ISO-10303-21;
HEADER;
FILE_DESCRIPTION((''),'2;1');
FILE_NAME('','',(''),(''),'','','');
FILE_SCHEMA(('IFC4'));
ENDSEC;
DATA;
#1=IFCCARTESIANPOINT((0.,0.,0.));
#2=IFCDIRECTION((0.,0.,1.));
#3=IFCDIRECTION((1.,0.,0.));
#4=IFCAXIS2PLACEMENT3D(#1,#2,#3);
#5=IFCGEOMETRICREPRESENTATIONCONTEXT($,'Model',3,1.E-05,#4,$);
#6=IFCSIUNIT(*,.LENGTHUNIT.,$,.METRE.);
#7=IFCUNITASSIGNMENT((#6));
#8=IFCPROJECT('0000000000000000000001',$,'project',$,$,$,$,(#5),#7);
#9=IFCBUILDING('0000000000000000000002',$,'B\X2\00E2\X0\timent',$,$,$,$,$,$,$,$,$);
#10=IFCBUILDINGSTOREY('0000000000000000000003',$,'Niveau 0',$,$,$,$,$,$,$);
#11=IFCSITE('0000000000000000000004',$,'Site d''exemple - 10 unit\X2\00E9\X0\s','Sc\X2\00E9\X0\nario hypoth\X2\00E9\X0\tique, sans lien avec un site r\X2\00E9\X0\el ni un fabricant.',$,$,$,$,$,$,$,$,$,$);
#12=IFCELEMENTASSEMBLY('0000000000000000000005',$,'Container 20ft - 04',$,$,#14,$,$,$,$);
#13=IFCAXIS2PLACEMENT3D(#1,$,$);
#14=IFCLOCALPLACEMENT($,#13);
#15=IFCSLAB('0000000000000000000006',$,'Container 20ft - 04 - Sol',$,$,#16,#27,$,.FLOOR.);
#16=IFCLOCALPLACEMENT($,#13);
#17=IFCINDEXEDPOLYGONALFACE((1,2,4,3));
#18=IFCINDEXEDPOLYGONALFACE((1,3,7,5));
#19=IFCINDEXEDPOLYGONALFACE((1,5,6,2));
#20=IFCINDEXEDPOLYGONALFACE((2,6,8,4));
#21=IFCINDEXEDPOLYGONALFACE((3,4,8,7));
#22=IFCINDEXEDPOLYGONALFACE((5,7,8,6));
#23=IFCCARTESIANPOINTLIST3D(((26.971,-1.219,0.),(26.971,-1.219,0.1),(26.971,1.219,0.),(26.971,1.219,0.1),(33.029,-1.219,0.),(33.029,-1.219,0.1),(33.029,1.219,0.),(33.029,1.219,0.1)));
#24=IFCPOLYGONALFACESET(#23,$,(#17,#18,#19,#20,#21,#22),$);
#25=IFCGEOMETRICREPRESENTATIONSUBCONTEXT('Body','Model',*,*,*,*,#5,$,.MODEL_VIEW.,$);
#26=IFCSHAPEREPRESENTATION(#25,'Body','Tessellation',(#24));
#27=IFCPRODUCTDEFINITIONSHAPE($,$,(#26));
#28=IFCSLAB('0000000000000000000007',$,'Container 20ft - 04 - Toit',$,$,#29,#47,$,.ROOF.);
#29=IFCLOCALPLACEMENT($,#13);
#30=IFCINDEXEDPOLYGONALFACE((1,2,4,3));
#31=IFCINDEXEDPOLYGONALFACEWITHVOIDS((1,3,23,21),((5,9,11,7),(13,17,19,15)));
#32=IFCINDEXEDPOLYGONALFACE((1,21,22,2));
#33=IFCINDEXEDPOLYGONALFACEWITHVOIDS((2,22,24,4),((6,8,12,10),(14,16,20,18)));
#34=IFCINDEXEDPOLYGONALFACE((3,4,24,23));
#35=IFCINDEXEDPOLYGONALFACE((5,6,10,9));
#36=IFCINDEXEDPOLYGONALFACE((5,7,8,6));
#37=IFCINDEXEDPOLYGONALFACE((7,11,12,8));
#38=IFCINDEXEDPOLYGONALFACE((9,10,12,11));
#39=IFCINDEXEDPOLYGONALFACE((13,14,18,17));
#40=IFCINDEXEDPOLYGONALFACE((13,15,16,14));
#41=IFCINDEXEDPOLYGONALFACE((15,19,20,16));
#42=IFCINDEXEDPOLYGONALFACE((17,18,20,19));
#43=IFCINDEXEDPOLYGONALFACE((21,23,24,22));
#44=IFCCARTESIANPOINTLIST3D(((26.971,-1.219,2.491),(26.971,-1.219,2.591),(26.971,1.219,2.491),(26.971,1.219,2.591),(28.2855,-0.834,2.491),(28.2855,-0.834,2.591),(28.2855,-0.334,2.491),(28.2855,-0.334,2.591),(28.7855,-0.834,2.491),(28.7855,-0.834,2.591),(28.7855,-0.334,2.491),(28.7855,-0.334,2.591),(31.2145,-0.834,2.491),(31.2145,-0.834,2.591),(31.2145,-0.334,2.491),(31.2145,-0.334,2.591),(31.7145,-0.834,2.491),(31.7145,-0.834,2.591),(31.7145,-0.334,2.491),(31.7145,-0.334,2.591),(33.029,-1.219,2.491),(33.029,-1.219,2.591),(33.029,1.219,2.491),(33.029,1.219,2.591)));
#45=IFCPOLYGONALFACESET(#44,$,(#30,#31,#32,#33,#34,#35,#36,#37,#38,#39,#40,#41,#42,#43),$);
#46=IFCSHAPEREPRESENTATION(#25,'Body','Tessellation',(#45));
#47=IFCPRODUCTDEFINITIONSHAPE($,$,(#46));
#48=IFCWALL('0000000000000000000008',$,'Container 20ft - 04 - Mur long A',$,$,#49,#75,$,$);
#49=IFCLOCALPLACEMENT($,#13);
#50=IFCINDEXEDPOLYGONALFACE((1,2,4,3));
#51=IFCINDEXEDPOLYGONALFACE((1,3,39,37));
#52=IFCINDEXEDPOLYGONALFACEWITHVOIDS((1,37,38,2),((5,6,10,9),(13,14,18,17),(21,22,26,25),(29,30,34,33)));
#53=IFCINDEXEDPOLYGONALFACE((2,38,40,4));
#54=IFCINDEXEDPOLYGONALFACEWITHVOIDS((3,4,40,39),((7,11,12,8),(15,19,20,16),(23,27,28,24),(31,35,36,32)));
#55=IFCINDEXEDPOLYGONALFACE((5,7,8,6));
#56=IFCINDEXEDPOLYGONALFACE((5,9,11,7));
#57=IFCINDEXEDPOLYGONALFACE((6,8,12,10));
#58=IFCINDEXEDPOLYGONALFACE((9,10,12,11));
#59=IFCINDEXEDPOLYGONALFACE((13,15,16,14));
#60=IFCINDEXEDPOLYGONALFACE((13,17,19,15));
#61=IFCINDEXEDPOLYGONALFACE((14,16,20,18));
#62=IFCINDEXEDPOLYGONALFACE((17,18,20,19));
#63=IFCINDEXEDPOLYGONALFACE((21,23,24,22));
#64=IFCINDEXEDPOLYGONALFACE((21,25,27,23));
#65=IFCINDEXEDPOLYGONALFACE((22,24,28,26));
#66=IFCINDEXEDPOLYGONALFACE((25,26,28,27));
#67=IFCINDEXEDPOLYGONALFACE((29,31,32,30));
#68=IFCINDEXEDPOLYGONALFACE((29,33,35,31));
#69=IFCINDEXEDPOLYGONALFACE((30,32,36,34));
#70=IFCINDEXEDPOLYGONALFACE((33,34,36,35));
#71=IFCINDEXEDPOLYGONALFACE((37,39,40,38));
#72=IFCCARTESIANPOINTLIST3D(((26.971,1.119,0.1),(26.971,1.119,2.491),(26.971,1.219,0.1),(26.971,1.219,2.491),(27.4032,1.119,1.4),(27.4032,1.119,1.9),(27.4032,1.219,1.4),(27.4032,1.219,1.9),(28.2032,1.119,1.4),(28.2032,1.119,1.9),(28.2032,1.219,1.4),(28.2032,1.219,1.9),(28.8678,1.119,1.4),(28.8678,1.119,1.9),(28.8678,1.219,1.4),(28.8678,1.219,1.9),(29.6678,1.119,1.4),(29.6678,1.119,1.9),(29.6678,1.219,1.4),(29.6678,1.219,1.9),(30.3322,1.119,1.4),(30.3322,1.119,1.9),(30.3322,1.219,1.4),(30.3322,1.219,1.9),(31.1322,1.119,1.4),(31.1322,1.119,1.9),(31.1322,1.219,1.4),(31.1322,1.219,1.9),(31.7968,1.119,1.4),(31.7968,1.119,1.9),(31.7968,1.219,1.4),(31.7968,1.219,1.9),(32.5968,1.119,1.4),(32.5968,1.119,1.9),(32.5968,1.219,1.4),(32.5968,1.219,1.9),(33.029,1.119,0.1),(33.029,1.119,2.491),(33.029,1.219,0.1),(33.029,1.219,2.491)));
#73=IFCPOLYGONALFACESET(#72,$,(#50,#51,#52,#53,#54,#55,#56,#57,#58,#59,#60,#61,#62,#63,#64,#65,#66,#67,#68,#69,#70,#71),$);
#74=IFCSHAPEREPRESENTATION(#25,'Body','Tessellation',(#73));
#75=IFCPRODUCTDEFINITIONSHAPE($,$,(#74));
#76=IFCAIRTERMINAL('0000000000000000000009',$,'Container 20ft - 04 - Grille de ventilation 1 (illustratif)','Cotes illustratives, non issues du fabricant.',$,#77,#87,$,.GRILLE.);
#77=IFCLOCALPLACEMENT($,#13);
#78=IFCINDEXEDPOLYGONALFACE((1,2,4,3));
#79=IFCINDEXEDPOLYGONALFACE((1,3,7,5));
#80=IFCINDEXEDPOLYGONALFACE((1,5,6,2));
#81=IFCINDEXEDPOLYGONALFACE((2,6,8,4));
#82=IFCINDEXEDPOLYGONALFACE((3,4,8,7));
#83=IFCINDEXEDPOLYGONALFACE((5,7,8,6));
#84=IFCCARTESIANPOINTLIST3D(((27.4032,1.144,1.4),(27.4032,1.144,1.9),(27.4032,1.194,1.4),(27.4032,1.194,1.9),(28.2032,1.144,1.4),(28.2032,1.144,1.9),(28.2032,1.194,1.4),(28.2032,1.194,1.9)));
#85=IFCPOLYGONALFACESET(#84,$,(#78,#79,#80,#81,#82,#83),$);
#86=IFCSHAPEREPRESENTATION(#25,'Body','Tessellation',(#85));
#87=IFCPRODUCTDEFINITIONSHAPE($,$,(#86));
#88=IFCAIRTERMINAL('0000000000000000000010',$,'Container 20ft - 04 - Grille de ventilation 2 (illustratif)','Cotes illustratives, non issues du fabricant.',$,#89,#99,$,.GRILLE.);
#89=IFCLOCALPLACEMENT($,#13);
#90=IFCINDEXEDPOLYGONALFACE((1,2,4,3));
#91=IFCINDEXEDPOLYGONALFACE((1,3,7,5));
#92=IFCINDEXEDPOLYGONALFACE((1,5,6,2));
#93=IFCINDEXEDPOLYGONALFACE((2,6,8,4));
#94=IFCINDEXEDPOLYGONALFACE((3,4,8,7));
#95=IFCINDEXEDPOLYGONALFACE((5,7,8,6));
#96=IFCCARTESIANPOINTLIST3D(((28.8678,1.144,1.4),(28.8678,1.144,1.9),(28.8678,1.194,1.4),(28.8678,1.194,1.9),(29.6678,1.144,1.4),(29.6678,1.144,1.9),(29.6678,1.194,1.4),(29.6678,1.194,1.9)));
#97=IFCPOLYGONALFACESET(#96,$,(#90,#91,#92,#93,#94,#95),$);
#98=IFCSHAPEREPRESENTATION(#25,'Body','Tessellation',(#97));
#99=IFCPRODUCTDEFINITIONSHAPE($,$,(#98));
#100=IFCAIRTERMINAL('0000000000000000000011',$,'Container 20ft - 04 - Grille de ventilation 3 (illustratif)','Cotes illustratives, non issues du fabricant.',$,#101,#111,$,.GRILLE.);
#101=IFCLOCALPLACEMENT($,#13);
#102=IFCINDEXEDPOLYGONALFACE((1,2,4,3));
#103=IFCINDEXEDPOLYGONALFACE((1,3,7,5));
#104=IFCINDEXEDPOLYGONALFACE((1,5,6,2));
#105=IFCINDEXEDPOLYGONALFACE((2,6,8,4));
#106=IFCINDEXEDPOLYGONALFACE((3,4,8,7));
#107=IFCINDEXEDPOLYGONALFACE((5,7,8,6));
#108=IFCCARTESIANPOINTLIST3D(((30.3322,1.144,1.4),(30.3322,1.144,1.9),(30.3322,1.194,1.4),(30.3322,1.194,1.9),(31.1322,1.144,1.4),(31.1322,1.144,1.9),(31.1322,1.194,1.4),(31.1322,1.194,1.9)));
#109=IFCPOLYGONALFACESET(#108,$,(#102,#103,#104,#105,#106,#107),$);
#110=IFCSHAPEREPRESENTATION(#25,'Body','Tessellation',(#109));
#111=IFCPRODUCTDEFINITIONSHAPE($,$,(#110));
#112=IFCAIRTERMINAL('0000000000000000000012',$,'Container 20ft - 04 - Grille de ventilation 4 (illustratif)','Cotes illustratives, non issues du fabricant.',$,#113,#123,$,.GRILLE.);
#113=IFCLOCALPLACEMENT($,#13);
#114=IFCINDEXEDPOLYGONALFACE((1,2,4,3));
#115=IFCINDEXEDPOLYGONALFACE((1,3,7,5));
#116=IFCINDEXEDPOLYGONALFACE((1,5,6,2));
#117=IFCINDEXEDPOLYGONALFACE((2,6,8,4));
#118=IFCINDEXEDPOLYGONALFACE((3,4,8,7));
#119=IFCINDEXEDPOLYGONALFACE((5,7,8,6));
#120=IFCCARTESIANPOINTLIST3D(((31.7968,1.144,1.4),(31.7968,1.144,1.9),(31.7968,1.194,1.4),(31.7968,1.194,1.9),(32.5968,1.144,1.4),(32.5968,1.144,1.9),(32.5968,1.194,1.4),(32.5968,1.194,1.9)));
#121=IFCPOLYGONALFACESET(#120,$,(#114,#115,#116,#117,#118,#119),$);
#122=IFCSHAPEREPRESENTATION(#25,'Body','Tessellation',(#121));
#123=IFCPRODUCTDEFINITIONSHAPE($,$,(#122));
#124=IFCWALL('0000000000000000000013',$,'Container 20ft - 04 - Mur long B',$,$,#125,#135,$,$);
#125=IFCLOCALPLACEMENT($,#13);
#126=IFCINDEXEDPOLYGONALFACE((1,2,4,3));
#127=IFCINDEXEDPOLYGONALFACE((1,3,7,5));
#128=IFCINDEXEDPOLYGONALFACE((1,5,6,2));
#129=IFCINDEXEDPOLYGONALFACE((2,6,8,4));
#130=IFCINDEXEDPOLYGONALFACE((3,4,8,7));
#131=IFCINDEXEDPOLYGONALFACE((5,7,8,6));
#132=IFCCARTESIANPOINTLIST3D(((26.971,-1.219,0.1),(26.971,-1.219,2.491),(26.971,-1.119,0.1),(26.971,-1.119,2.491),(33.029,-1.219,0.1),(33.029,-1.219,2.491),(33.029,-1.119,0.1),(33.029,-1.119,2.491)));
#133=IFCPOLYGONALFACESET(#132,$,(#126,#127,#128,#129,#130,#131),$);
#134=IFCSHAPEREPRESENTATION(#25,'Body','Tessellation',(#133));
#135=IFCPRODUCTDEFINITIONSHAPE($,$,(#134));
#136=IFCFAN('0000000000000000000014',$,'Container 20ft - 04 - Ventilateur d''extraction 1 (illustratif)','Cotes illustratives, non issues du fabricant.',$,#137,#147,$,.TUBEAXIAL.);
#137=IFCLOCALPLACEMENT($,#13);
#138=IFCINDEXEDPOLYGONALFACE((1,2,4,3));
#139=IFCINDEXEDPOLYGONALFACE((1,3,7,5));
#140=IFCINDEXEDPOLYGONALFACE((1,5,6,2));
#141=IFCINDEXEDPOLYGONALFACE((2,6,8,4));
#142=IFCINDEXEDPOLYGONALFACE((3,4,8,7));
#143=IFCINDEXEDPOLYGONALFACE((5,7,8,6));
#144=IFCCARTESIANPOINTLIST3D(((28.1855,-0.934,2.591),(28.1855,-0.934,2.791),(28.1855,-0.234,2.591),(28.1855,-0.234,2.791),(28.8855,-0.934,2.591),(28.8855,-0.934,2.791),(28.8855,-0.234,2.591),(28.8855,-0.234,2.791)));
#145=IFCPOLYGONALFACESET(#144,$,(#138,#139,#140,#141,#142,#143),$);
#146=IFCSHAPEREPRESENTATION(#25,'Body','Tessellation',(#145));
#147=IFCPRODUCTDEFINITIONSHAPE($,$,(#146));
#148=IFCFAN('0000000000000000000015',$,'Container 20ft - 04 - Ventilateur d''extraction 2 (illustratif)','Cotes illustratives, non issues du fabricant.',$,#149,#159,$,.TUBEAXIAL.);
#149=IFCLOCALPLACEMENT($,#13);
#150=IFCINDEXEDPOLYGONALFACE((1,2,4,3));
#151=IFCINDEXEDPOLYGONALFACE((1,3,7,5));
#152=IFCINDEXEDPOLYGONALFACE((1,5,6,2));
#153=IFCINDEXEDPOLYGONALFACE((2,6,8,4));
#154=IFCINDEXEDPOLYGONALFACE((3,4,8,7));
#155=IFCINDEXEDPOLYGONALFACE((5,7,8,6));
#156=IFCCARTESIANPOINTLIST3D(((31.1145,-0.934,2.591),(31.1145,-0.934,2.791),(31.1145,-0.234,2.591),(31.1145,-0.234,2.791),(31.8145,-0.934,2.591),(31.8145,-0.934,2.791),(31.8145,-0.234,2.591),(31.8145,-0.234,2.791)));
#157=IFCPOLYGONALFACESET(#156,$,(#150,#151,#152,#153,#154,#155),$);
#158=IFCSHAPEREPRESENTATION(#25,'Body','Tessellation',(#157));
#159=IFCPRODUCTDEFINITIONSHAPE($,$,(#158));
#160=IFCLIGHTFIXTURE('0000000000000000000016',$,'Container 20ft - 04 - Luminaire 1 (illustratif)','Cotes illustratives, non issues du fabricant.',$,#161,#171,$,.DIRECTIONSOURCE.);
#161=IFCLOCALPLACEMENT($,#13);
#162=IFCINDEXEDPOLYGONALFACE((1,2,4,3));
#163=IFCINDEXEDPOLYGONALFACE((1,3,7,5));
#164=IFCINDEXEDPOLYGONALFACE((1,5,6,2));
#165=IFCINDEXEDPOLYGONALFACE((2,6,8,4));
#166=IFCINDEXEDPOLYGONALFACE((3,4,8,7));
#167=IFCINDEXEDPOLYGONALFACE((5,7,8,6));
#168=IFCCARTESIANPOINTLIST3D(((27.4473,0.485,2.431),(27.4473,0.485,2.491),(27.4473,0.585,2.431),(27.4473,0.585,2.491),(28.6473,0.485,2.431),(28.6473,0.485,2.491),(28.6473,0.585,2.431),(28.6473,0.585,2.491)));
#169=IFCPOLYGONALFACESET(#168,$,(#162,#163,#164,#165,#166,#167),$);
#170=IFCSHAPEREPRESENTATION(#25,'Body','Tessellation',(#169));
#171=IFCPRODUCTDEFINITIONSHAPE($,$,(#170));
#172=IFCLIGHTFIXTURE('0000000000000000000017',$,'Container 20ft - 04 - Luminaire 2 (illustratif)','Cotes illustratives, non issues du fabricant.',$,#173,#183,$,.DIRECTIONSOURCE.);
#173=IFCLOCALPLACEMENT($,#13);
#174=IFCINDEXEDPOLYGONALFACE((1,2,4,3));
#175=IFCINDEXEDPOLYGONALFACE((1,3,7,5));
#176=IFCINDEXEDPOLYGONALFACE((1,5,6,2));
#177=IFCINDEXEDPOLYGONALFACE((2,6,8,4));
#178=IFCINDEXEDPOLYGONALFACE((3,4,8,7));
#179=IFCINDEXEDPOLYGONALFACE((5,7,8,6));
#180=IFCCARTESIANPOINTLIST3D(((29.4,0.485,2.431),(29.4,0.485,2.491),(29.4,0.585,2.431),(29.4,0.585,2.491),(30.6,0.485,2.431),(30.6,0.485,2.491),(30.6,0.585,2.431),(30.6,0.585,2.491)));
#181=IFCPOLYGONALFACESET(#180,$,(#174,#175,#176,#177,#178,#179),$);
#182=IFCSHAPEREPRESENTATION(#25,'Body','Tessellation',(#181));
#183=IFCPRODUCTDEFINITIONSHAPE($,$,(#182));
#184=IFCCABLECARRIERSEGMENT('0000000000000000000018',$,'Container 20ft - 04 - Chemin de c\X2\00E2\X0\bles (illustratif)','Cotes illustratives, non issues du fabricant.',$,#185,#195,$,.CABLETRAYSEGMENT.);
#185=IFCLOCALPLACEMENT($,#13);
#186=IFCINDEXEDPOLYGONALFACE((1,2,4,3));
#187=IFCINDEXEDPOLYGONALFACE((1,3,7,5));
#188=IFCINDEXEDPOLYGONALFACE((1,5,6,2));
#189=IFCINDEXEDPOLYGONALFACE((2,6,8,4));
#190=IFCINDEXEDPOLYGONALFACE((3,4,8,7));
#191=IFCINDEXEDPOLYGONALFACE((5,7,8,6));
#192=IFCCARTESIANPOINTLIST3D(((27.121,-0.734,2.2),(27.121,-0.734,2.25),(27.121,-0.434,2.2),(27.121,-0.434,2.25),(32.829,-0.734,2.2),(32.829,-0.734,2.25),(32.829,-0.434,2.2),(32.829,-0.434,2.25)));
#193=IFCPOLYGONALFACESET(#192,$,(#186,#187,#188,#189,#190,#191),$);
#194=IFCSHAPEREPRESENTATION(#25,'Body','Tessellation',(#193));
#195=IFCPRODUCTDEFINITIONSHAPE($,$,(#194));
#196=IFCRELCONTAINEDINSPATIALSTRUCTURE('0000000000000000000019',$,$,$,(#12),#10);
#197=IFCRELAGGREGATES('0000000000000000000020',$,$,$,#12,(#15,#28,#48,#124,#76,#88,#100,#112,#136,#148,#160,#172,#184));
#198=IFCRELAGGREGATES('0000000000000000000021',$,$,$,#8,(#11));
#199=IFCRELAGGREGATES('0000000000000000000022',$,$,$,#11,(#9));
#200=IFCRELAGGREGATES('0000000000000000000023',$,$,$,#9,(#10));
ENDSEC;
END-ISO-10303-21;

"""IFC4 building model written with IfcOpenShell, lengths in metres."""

from ifc_helpers import new_model, si_unit, frame, origin_with_axes, place, context, subcontext, project, spatial, rectangle, extrude, element, fill, aggregate, save


model = new_model("IFC4")

# Units and contexts
model_context = context("Model", 3, precision=1e-05, world=origin_with_axes())
body_context = subcontext(model_context, "Body", "Model", "MODEL_VIEW")
ifc_project = project(units=[si_unit("LENGTHUNIT", "METRE")], contexts=[model_context])

# Site, building, storey
site = spatial("IfcSite", under=ifc_project, Name="Site d'exemple - 10 unités", Description="Scénario hypothétique, sans lien avec un site réel ni un fabricant.")
building = spatial("IfcBuilding", under=site, Name="Bâtiment")
storey = spatial("IfcBuildingStorey", under=building, Name="Niveau 0")

# Element assembly, slabs, openings, walls, air terminals, fans, light fixtures, cable carrier segment
assembly = element("IfcElementAssembly", 1, inside=storey, Name="Container 20ft - 04")
slab_1_placement = place(None, frame((30.0, 0.0, 0.0), z_axis=(0.0, 0.0, 1.0), x_axis=(1.0, 0.0, 0.0)))
slab_1 = element("IfcSlab", 2, at=slab_1_placement, Name="Container 20ft - 04 - Sol", PredefinedType="FLOOR", context=body_context, shape_type="SweptSolid", body=[
    extrude(rectangle(XDim=6.058, YDim=2.438), origin_with_axes(), (0.0, 0.0, 1.0), 0.1),
])
slab_2_placement = place(None, frame((30.0, 0.0, 2.491), z_axis=(0.0, 0.0, 1.0), x_axis=(1.0, 0.0, 0.0)))
slab_2 = element("IfcSlab", 3, at=slab_2_placement, Name="Container 20ft - 04 - Toit", PredefinedType="ROOF", context=body_context, shape_type="SweptSolid", body=[
    extrude(rectangle(XDim=6.058, YDim=2.438), origin_with_axes(), (0.0, 0.0, 1.0), 0.1),
])
opening_1_placement = place(None, frame((28.5355, -0.584, 2.441), z_axis=(0.0, 0.0, 1.0), x_axis=(1.0, 0.0, 0.0)))
element("IfcOpeningElement", 4, at=opening_1_placement, cuts=slab_2, PredefinedType="OPENING", context=body_context, shape_type="SweptSolid", body=[
    extrude(rectangle(XDim=0.5, YDim=0.5), origin_with_axes(), (0.0, 0.0, 1.0), 0.2),
])
opening_2_placement = place(None, frame((31.4645, -0.584, 2.441), z_axis=(0.0, 0.0, 1.0), x_axis=(1.0, 0.0, 0.0)))
element("IfcOpeningElement", 5, at=opening_2_placement, cuts=slab_2, PredefinedType="OPENING", context=body_context, shape_type="SweptSolid", body=[
    extrude(rectangle(XDim=0.5, YDim=0.5), origin_with_axes(), (0.0, 0.0, 1.0), 0.2),
])
wall_1_placement = place(None, frame((30.0, 1.169, 0.1), z_axis=(0.0, 0.0, 1.0), x_axis=(1.0, 0.0, 0.0)))
wall_1 = element("IfcWall", 6, at=wall_1_placement, Name="Container 20ft - 04 - Mur long A", context=body_context, shape_type="SweptSolid", body=[
    extrude(rectangle(XDim=6.058, YDim=0.1), origin_with_axes(), (0.0, 0.0, 1.0), 2.391),
])
opening_3_placement = place(None, frame((27.8032, 1.169, 1.4), z_axis=(0.0, 0.0, 1.0), x_axis=(1.0, 0.0, 0.0)))
opening_3 = element("IfcOpeningElement", 7, at=opening_3_placement, cuts=wall_1, PredefinedType="OPENING", context=body_context, shape_type="SweptSolid", body=[
    extrude(rectangle(XDim=0.8, YDim=0.2), origin_with_axes(), (0.0, 0.0, 1.0), 0.5),
])
opening_4_placement = place(None, frame((29.2677, 1.169, 1.4), z_axis=(0.0, 0.0, 1.0), x_axis=(1.0, 0.0, 0.0)))
opening_4 = element("IfcOpeningElement", 8, at=opening_4_placement, cuts=wall_1, PredefinedType="OPENING", context=body_context, shape_type="SweptSolid", body=[
    extrude(rectangle(XDim=0.8, YDim=0.2), origin_with_axes(), (0.0, 0.0, 1.0), 0.5),
])
opening_5_placement = place(None, frame((30.7323, 1.169, 1.4), z_axis=(0.0, 0.0, 1.0), x_axis=(1.0, 0.0, 0.0)))
opening_5 = element("IfcOpeningElement", 9, at=opening_5_placement, cuts=wall_1, PredefinedType="OPENING", context=body_context, shape_type="SweptSolid", body=[
    extrude(rectangle(XDim=0.8, YDim=0.2), origin_with_axes(), (0.0, 0.0, 1.0), 0.5),
])
opening_6_placement = place(None, frame((32.1968, 1.169, 1.4), z_axis=(0.0, 0.0, 1.0), x_axis=(1.0, 0.0, 0.0)))
opening_6 = element("IfcOpeningElement", 10, at=opening_6_placement, cuts=wall_1, PredefinedType="OPENING", context=body_context, shape_type="SweptSolid", body=[
    extrude(rectangle(XDim=0.8, YDim=0.2), origin_with_axes(), (0.0, 0.0, 1.0), 0.5),
])
air_terminal_1_placement = place(None, frame((27.8032, 1.169, 1.4), z_axis=(0.0, 0.0, 1.0), x_axis=(1.0, 0.0, 0.0)))
air_terminal_1 = element("IfcAirTerminal", 11, at=air_terminal_1_placement, Name="Container 20ft - 04 - Grille de ventilation 1 (illustratif)", Description="Cotes illustratives, non issues du fabricant.", PredefinedType="GRILLE", context=body_context, shape_type="SweptSolid", body=[
    extrude(rectangle(XDim=0.8, YDim=0.05), origin_with_axes(), (0.0, 0.0, 1.0), 0.5),
])
fill(opening_3, air_terminal_1)
air_terminal_2_placement = place(None, frame((29.2677, 1.169, 1.4), z_axis=(0.0, 0.0, 1.0), x_axis=(1.0, 0.0, 0.0)))
air_terminal_2 = element("IfcAirTerminal", 12, at=air_terminal_2_placement, Name="Container 20ft - 04 - Grille de ventilation 2 (illustratif)", Description="Cotes illustratives, non issues du fabricant.", PredefinedType="GRILLE", context=body_context, shape_type="SweptSolid", body=[
    extrude(rectangle(XDim=0.8, YDim=0.05), origin_with_axes(), (0.0, 0.0, 1.0), 0.5),
])
fill(opening_4, air_terminal_2)
air_terminal_3_placement = place(None, frame((30.7323, 1.169, 1.4), z_axis=(0.0, 0.0, 1.0), x_axis=(1.0, 0.0, 0.0)))
air_terminal_3 = element("IfcAirTerminal", 13, at=air_terminal_3_placement, Name="Container 20ft - 04 - Grille de ventilation 3 (illustratif)", Description="Cotes illustratives, non issues du fabricant.", PredefinedType="GRILLE", context=body_context, shape_type="SweptSolid", body=[
    extrude(rectangle(XDim=0.8, YDim=0.05), origin_with_axes(), (0.0, 0.0, 1.0), 0.5),
])
fill(opening_5, air_terminal_3)
air_terminal_4_placement = place(None, frame((32.1968, 1.169, 1.4), z_axis=(0.0, 0.0, 1.0), x_axis=(1.0, 0.0, 0.0)))
air_terminal_4 = element("IfcAirTerminal", 14, at=air_terminal_4_placement, Name="Container 20ft - 04 - Grille de ventilation 4 (illustratif)", Description="Cotes illustratives, non issues du fabricant.", PredefinedType="GRILLE", context=body_context, shape_type="SweptSolid", body=[
    extrude(rectangle(XDim=0.8, YDim=0.05), origin_with_axes(), (0.0, 0.0, 1.0), 0.5),
])
fill(opening_6, air_terminal_4)
wall_2_placement = place(None, frame((30.0, -1.169, 0.1), z_axis=(0.0, 0.0, 1.0), x_axis=(1.0, 0.0, 0.0)))
wall_2 = element("IfcWall", 15, at=wall_2_placement, Name="Container 20ft - 04 - Mur long B", context=body_context, shape_type="SweptSolid", body=[
    extrude(rectangle(XDim=6.058, YDim=0.1), origin_with_axes(), (0.0, 0.0, 1.0), 2.391),
])
fan_1_placement = place(None, frame((28.5355, -0.584, 2.591), z_axis=(0.0, 0.0, 1.0), x_axis=(1.0, 0.0, 0.0)))
fan_1 = element("IfcFan", 16, at=fan_1_placement, Name="Container 20ft - 04 - Ventilateur d'extraction 1 (illustratif)", Description="Cotes illustratives, non issues du fabricant.", PredefinedType="TUBEAXIAL", context=body_context, shape_type="SweptSolid", body=[
    extrude(rectangle(XDim=0.7, YDim=0.7), origin_with_axes(), (0.0, 0.0, 1.0), 0.2),
])
fan_2_placement = place(None, frame((31.4645, -0.584, 2.591), z_axis=(0.0, 0.0, 1.0), x_axis=(1.0, 0.0, 0.0)))
fan_2 = element("IfcFan", 17, at=fan_2_placement, Name="Container 20ft - 04 - Ventilateur d'extraction 2 (illustratif)", Description="Cotes illustratives, non issues du fabricant.", PredefinedType="TUBEAXIAL", context=body_context, shape_type="SweptSolid", body=[
    extrude(rectangle(XDim=0.7, YDim=0.7), origin_with_axes(), (0.0, 0.0, 1.0), 0.2),
])
light_fixture_1_placement = place(None, frame((28.0473, 0.535, 2.431), z_axis=(0.0, 0.0, 1.0), x_axis=(1.0, 0.0, 0.0)))
light_fixture_1 = element("IfcLightFixture", 18, at=light_fixture_1_placement, Name="Container 20ft - 04 - Luminaire 1 (illustratif)", Description="Cotes illustratives, non issues du fabricant.", PredefinedType="DIRECTIONSOURCE", context=body_context, shape_type="SweptSolid", body=[
    extrude(rectangle(XDim=1.2, YDim=0.1), origin_with_axes(), (0.0, 0.0, 1.0), 0.06),
])
light_fixture_2_placement = place(None, frame((30.0, 0.535, 2.431), z_axis=(0.0, 0.0, 1.0), x_axis=(1.0, 0.0, 0.0)))
light_fixture_2 = element("IfcLightFixture", 19, at=light_fixture_2_placement, Name="Container 20ft - 04 - Luminaire 2 (illustratif)", Description="Cotes illustratives, non issues du fabricant.", PredefinedType="DIRECTIONSOURCE", context=body_context, shape_type="SweptSolid", body=[
    extrude(rectangle(XDim=1.2, YDim=0.1), origin_with_axes(), (0.0, 0.0, 1.0), 0.06),
])
cable_carrier_segment_placement = place(None, frame((29.975, -0.584, 2.2), z_axis=(0.0, 0.0, 1.0), x_axis=(1.0, 0.0, 0.0)))
cable_carrier_segment = element("IfcCableCarrierSegment", 20, at=cable_carrier_segment_placement, Name="Container 20ft - 04 - Chemin de câbles (illustratif)", Description="Cotes illustratives, non issues du fabricant.", PredefinedType="CABLETRAYSEGMENT", context=body_context, shape_type="SweptSolid", body=[
    extrude(rectangle(XDim=5.708, YDim=0.3), origin_with_axes(), (0.0, 0.0, 1.0), 0.05),
])
aggregate(assembly, [slab_1, slab_2, wall_1, wall_2, air_terminal_1, air_terminal_2, air_terminal_3, air_terminal_4, fan_1, fan_2, light_fixture_1, light_fixture_2, cable_carrier_segment])

save(model, "model.ifc")
